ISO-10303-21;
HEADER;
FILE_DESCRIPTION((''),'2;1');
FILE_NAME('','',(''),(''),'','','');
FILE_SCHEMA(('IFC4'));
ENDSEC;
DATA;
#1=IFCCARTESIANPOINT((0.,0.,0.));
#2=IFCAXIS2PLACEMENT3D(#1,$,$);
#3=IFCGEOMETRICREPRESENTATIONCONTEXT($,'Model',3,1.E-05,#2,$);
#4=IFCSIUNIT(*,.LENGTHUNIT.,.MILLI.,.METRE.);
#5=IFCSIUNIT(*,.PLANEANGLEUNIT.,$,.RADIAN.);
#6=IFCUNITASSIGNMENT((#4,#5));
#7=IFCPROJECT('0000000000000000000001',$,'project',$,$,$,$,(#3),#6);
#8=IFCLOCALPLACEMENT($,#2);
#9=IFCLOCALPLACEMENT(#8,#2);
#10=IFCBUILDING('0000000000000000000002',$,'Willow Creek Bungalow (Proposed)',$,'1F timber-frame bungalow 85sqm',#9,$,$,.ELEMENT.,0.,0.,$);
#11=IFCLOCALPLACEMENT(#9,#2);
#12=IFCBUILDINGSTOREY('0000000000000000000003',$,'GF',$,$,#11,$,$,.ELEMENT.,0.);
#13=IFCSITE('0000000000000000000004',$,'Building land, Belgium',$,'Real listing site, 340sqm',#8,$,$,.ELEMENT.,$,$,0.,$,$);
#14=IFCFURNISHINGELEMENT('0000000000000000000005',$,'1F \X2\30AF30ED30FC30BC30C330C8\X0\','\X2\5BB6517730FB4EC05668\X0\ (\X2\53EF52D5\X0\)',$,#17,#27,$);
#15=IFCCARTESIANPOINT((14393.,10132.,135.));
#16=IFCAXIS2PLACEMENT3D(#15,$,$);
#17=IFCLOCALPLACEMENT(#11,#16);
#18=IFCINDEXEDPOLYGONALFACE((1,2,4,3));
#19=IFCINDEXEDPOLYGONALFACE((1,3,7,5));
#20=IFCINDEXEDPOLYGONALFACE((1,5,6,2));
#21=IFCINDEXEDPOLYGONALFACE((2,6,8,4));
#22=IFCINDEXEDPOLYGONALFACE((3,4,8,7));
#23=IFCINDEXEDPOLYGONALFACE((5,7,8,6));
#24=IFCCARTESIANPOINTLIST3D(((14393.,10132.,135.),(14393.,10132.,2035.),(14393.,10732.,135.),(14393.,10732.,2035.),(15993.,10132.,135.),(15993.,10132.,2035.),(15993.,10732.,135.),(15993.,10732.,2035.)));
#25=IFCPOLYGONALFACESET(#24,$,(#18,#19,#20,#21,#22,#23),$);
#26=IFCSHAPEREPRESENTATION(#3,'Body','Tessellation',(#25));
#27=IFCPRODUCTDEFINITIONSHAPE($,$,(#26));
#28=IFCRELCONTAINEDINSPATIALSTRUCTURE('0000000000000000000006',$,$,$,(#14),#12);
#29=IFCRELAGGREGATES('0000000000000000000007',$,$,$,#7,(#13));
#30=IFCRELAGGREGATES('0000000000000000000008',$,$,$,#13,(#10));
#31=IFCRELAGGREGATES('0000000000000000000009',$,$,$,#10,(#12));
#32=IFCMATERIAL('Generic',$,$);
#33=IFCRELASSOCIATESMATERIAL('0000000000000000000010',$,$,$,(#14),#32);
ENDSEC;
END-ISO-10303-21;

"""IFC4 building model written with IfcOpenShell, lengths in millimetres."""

from ifc_helpers import new_model, si_unit, frame, frame_2d, origin, place, context, project, spatial, rectangle, extrude, material, element, save


model = new_model("IFC4")

# Units and contexts
model_context = context("Model", 3, precision=1e-05, world=origin())
ifc_project = project(units=[si_unit("LENGTHUNIT", "METRE", prefix="MILLI"), si_unit("PLANEANGLEUNIT", "RADIAN")], contexts=[model_context])

# Site, building, storey
site_placement = place(None, origin())
site = spatial("IfcSite", under=ifc_project, at=site_placement, Name="Building land, Belgium", ObjectType="Real listing site, 340sqm", CompositionType="ELEMENT", RefElevation=0.0)
building_placement = place(site_placement, origin())
building = spatial("IfcBuilding", under=site, at=building_placement, Name="Willow Creek Bungalow (Proposed)", ObjectType="1F timber-frame bungalow 85sqm", CompositionType="ELEMENT", ElevationOfRefHeight=0.0, ElevationOfTerrain=0.0)
storey_placement = place(building_placement, origin())
storey = spatial("IfcBuildingStorey", under=building, at=storey_placement, Name="GF", CompositionType="ELEMENT", Elevation=0.0)

# Shared definitions
ifc_material_1 = material(Name="Generic")

# Furnishing element
furnishing_placement = place(storey_placement, frame((14393.0, 10132.0, 135.0)))
element("IfcFurnishingElement", 1, at=furnishing_placement, inside=storey, material=ifc_material_1, Name="1F クローゼット", Description="家具・什器 (可動)", context=model_context, shape_type="SweptSolid", body=[
    extrude(rectangle(XDim=1600.0, YDim=600.0, at=frame_2d((800.0, 300.0))), frame((14393.0, 10132.0, 135.0)), (0.0, 0.0, 1.0), 1900.0),
])

save(model, "model.ifc")
